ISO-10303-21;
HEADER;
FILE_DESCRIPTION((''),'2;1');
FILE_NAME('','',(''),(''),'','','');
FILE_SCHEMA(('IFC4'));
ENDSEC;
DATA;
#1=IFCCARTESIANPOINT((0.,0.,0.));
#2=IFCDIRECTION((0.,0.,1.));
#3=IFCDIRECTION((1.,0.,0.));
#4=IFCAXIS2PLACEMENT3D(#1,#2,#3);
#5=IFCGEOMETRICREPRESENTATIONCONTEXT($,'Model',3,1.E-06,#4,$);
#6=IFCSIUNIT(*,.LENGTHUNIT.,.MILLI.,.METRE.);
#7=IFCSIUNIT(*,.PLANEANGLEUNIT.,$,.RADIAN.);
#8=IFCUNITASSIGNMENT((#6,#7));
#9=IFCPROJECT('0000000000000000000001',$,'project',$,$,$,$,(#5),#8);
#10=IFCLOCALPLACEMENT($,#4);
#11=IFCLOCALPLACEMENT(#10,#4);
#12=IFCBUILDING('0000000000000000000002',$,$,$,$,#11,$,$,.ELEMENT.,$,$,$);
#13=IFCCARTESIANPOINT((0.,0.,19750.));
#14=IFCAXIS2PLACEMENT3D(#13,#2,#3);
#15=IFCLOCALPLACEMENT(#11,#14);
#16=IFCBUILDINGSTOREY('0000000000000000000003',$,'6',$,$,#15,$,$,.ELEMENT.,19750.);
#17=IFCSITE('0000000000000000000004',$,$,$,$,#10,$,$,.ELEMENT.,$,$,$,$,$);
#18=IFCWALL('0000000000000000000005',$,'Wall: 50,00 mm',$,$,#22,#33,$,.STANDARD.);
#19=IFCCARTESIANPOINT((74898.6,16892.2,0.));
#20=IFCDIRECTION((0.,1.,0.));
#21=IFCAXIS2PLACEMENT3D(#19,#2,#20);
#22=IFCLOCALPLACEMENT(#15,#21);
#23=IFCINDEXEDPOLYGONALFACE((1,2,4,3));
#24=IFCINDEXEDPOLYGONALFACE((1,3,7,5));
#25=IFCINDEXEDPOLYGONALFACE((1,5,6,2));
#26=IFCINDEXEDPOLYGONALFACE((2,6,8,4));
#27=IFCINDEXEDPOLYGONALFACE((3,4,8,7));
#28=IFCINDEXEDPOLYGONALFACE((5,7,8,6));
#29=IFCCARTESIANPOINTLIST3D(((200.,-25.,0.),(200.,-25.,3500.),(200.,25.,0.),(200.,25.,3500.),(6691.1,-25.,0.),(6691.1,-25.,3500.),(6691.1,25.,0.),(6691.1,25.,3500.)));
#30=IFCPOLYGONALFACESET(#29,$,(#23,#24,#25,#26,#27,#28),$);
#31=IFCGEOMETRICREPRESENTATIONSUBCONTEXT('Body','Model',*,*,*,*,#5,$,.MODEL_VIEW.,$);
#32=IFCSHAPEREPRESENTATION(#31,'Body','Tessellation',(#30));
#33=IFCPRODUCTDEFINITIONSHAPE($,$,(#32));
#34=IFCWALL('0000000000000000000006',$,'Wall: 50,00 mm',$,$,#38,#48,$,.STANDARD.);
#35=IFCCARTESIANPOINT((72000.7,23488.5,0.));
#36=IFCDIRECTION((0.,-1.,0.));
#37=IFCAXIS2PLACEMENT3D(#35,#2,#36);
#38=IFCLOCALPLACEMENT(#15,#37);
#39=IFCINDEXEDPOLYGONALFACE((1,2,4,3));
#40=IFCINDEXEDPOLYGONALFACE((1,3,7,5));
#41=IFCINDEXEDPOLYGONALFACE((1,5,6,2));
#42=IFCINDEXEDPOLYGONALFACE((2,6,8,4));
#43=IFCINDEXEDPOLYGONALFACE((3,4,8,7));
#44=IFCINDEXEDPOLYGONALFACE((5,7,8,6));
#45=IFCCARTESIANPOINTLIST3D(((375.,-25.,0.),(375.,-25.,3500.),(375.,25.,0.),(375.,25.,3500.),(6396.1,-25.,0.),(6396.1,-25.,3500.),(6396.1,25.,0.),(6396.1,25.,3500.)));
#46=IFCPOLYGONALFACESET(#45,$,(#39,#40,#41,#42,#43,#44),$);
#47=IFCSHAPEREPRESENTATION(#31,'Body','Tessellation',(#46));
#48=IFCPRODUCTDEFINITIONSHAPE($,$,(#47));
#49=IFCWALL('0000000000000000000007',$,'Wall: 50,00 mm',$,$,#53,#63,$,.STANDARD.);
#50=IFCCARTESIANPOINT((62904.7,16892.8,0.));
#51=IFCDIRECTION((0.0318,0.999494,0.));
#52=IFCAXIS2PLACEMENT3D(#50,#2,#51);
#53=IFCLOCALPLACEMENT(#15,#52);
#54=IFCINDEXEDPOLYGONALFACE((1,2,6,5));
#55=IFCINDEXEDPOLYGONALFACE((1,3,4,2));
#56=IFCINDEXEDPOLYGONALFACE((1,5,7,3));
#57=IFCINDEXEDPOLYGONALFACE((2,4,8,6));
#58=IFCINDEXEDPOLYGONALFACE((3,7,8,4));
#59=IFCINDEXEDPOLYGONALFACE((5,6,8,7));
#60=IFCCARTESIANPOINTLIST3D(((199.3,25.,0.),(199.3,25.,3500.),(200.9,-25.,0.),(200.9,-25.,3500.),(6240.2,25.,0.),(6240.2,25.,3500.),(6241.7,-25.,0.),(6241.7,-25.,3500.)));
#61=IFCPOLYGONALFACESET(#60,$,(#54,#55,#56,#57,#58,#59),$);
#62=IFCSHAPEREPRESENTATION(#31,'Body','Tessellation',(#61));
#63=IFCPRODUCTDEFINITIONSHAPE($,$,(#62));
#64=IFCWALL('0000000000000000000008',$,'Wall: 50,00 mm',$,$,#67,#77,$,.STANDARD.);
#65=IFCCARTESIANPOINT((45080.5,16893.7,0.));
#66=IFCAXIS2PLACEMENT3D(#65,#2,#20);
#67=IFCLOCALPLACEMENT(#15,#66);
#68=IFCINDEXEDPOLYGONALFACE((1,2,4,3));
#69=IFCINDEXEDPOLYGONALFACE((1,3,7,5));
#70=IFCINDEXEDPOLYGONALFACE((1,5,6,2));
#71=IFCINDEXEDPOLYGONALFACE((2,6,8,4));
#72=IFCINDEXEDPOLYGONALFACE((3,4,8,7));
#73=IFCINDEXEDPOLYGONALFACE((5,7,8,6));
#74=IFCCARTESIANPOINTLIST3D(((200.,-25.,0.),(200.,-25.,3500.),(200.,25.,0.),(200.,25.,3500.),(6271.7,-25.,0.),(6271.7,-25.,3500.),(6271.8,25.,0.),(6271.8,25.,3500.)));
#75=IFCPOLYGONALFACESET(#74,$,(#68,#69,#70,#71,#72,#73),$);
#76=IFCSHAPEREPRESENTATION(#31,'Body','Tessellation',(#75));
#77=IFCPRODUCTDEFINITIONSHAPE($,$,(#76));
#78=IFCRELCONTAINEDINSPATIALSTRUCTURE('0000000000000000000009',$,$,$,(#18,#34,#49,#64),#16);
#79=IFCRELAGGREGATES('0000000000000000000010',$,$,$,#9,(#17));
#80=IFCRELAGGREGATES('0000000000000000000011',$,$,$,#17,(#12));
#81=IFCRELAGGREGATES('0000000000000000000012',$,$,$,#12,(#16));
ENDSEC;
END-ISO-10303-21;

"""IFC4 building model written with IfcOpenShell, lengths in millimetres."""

from ifc_helpers import new_model, si_unit, frame, origin_with_axes, place, context, subcontext, project, spatial, line, indexed_curve, outline, extrude, element, save


model = new_model("IFC4")

# Units and contexts
model_context = context("Model", 3, precision=1e-06, world=origin_with_axes())
body_context = subcontext(model_context, "Body", "Model", "MODEL_VIEW")
ifc_project = project(units=[si_unit("LENGTHUNIT", "METRE", prefix="MILLI"), si_unit("PLANEANGLEUNIT", "RADIAN")], contexts=[model_context])

# Site, building, storey
site_placement = place(None, origin_with_axes())
site = spatial("IfcSite", under=ifc_project, at=site_placement, CompositionType="ELEMENT")
building_placement = place(site_placement, origin_with_axes())
building = spatial("IfcBuilding", under=site, at=building_placement, CompositionType="ELEMENT")
storey_placement = place(building_placement, frame((0.0, 0.0, 19750.0), z_axis=(0.0, 0.0, 1.0), x_axis=(1.0, 0.0, 0.0)))
storey = spatial("IfcBuildingStorey", under=building, at=storey_placement, Name="6", CompositionType="ELEMENT", Elevation=19750.0)

# Walls
wall_1_placement = place(storey_placement, frame((74898.6, 16892.2, 0.0), z_axis=(0.0, 0.0, 1.0), x_axis=(0.0, 1.0, 0.0)))
element("IfcWall", 1, at=wall_1_placement, inside=storey, Name="Wall: 50,00 mm", PredefinedType="STANDARD", context=body_context, shape_type="SweptSolid", body=[
    extrude(outline(indexed_curve([(200.0, -25.0), (6691.1, -25.0), (6691.1, 25.0), (200.0, 25.0)], segments=[line(1, 2), line(2, 3), line(3, 4), line(4, 1)])), origin_with_axes(), (0.0, 0.0, 1.0), 3500.0),
])
wall_2_placement = place(storey_placement, frame((72000.7, 23488.5, 0.0), z_axis=(0.0, 0.0, 1.0), x_axis=(0.0, -1.0, 0.0)))
element("IfcWall", 2, at=wall_2_placement, inside=storey, Name="Wall: 50,00 mm", PredefinedType="STANDARD", context=body_context, shape_type="SweptSolid", body=[
    extrude(outline(indexed_curve([(375.0, -25.0), (6396.1, -25.0), (6396.1, 25.0), (375.0, 25.0)], segments=[line(1, 2), line(2, 3), line(3, 4), line(4, 1)])), origin_with_axes(), (0.0, 0.0, 1.0), 3500.0),
])
wall_3_placement = place(storey_placement, frame((62904.7, 16892.8, 0.0), z_axis=(0.0, 0.0, 1.0), x_axis=(0.0318, 0.999494, 0.0)))
element("IfcWall", 3, at=wall_3_placement, inside=storey, Name="Wall: 50,00 mm", PredefinedType="STANDARD", context=body_context, shape_type="SweptSolid", body=[
    extrude(outline(indexed_curve([(200.9, -25.0), (6241.7, -25.0), (6240.2, 25.0), (199.3, 25.0)], segments=[line(1, 2), line(2, 3), line(3, 4), line(4, 1)])), origin_with_axes(), (0.0, 0.0, 1.0), 3500.0),
])
wall_4_placement = place(storey_placement, frame((45080.5, 16893.7, 0.0), z_axis=(0.0, 0.0, 1.0), x_axis=(0.0, 1.0, 0.0)))
element("IfcWall", 4, at=wall_4_placement, inside=storey, Name="Wall: 50,00 mm", PredefinedType="STANDARD", context=body_context, shape_type="SweptSolid", body=[
    extrude(outline(indexed_curve([(200.0, -25.0), (6271.7, -25.0), (6271.8, 25.0), (200.0, 25.0)], segments=[line(1, 2), line(2, 3), line(3, 4), line(4, 1)])), origin_with_axes(), (0.0, 0.0, 1.0), 3500.0),
])

save(model, "model.ifc")
